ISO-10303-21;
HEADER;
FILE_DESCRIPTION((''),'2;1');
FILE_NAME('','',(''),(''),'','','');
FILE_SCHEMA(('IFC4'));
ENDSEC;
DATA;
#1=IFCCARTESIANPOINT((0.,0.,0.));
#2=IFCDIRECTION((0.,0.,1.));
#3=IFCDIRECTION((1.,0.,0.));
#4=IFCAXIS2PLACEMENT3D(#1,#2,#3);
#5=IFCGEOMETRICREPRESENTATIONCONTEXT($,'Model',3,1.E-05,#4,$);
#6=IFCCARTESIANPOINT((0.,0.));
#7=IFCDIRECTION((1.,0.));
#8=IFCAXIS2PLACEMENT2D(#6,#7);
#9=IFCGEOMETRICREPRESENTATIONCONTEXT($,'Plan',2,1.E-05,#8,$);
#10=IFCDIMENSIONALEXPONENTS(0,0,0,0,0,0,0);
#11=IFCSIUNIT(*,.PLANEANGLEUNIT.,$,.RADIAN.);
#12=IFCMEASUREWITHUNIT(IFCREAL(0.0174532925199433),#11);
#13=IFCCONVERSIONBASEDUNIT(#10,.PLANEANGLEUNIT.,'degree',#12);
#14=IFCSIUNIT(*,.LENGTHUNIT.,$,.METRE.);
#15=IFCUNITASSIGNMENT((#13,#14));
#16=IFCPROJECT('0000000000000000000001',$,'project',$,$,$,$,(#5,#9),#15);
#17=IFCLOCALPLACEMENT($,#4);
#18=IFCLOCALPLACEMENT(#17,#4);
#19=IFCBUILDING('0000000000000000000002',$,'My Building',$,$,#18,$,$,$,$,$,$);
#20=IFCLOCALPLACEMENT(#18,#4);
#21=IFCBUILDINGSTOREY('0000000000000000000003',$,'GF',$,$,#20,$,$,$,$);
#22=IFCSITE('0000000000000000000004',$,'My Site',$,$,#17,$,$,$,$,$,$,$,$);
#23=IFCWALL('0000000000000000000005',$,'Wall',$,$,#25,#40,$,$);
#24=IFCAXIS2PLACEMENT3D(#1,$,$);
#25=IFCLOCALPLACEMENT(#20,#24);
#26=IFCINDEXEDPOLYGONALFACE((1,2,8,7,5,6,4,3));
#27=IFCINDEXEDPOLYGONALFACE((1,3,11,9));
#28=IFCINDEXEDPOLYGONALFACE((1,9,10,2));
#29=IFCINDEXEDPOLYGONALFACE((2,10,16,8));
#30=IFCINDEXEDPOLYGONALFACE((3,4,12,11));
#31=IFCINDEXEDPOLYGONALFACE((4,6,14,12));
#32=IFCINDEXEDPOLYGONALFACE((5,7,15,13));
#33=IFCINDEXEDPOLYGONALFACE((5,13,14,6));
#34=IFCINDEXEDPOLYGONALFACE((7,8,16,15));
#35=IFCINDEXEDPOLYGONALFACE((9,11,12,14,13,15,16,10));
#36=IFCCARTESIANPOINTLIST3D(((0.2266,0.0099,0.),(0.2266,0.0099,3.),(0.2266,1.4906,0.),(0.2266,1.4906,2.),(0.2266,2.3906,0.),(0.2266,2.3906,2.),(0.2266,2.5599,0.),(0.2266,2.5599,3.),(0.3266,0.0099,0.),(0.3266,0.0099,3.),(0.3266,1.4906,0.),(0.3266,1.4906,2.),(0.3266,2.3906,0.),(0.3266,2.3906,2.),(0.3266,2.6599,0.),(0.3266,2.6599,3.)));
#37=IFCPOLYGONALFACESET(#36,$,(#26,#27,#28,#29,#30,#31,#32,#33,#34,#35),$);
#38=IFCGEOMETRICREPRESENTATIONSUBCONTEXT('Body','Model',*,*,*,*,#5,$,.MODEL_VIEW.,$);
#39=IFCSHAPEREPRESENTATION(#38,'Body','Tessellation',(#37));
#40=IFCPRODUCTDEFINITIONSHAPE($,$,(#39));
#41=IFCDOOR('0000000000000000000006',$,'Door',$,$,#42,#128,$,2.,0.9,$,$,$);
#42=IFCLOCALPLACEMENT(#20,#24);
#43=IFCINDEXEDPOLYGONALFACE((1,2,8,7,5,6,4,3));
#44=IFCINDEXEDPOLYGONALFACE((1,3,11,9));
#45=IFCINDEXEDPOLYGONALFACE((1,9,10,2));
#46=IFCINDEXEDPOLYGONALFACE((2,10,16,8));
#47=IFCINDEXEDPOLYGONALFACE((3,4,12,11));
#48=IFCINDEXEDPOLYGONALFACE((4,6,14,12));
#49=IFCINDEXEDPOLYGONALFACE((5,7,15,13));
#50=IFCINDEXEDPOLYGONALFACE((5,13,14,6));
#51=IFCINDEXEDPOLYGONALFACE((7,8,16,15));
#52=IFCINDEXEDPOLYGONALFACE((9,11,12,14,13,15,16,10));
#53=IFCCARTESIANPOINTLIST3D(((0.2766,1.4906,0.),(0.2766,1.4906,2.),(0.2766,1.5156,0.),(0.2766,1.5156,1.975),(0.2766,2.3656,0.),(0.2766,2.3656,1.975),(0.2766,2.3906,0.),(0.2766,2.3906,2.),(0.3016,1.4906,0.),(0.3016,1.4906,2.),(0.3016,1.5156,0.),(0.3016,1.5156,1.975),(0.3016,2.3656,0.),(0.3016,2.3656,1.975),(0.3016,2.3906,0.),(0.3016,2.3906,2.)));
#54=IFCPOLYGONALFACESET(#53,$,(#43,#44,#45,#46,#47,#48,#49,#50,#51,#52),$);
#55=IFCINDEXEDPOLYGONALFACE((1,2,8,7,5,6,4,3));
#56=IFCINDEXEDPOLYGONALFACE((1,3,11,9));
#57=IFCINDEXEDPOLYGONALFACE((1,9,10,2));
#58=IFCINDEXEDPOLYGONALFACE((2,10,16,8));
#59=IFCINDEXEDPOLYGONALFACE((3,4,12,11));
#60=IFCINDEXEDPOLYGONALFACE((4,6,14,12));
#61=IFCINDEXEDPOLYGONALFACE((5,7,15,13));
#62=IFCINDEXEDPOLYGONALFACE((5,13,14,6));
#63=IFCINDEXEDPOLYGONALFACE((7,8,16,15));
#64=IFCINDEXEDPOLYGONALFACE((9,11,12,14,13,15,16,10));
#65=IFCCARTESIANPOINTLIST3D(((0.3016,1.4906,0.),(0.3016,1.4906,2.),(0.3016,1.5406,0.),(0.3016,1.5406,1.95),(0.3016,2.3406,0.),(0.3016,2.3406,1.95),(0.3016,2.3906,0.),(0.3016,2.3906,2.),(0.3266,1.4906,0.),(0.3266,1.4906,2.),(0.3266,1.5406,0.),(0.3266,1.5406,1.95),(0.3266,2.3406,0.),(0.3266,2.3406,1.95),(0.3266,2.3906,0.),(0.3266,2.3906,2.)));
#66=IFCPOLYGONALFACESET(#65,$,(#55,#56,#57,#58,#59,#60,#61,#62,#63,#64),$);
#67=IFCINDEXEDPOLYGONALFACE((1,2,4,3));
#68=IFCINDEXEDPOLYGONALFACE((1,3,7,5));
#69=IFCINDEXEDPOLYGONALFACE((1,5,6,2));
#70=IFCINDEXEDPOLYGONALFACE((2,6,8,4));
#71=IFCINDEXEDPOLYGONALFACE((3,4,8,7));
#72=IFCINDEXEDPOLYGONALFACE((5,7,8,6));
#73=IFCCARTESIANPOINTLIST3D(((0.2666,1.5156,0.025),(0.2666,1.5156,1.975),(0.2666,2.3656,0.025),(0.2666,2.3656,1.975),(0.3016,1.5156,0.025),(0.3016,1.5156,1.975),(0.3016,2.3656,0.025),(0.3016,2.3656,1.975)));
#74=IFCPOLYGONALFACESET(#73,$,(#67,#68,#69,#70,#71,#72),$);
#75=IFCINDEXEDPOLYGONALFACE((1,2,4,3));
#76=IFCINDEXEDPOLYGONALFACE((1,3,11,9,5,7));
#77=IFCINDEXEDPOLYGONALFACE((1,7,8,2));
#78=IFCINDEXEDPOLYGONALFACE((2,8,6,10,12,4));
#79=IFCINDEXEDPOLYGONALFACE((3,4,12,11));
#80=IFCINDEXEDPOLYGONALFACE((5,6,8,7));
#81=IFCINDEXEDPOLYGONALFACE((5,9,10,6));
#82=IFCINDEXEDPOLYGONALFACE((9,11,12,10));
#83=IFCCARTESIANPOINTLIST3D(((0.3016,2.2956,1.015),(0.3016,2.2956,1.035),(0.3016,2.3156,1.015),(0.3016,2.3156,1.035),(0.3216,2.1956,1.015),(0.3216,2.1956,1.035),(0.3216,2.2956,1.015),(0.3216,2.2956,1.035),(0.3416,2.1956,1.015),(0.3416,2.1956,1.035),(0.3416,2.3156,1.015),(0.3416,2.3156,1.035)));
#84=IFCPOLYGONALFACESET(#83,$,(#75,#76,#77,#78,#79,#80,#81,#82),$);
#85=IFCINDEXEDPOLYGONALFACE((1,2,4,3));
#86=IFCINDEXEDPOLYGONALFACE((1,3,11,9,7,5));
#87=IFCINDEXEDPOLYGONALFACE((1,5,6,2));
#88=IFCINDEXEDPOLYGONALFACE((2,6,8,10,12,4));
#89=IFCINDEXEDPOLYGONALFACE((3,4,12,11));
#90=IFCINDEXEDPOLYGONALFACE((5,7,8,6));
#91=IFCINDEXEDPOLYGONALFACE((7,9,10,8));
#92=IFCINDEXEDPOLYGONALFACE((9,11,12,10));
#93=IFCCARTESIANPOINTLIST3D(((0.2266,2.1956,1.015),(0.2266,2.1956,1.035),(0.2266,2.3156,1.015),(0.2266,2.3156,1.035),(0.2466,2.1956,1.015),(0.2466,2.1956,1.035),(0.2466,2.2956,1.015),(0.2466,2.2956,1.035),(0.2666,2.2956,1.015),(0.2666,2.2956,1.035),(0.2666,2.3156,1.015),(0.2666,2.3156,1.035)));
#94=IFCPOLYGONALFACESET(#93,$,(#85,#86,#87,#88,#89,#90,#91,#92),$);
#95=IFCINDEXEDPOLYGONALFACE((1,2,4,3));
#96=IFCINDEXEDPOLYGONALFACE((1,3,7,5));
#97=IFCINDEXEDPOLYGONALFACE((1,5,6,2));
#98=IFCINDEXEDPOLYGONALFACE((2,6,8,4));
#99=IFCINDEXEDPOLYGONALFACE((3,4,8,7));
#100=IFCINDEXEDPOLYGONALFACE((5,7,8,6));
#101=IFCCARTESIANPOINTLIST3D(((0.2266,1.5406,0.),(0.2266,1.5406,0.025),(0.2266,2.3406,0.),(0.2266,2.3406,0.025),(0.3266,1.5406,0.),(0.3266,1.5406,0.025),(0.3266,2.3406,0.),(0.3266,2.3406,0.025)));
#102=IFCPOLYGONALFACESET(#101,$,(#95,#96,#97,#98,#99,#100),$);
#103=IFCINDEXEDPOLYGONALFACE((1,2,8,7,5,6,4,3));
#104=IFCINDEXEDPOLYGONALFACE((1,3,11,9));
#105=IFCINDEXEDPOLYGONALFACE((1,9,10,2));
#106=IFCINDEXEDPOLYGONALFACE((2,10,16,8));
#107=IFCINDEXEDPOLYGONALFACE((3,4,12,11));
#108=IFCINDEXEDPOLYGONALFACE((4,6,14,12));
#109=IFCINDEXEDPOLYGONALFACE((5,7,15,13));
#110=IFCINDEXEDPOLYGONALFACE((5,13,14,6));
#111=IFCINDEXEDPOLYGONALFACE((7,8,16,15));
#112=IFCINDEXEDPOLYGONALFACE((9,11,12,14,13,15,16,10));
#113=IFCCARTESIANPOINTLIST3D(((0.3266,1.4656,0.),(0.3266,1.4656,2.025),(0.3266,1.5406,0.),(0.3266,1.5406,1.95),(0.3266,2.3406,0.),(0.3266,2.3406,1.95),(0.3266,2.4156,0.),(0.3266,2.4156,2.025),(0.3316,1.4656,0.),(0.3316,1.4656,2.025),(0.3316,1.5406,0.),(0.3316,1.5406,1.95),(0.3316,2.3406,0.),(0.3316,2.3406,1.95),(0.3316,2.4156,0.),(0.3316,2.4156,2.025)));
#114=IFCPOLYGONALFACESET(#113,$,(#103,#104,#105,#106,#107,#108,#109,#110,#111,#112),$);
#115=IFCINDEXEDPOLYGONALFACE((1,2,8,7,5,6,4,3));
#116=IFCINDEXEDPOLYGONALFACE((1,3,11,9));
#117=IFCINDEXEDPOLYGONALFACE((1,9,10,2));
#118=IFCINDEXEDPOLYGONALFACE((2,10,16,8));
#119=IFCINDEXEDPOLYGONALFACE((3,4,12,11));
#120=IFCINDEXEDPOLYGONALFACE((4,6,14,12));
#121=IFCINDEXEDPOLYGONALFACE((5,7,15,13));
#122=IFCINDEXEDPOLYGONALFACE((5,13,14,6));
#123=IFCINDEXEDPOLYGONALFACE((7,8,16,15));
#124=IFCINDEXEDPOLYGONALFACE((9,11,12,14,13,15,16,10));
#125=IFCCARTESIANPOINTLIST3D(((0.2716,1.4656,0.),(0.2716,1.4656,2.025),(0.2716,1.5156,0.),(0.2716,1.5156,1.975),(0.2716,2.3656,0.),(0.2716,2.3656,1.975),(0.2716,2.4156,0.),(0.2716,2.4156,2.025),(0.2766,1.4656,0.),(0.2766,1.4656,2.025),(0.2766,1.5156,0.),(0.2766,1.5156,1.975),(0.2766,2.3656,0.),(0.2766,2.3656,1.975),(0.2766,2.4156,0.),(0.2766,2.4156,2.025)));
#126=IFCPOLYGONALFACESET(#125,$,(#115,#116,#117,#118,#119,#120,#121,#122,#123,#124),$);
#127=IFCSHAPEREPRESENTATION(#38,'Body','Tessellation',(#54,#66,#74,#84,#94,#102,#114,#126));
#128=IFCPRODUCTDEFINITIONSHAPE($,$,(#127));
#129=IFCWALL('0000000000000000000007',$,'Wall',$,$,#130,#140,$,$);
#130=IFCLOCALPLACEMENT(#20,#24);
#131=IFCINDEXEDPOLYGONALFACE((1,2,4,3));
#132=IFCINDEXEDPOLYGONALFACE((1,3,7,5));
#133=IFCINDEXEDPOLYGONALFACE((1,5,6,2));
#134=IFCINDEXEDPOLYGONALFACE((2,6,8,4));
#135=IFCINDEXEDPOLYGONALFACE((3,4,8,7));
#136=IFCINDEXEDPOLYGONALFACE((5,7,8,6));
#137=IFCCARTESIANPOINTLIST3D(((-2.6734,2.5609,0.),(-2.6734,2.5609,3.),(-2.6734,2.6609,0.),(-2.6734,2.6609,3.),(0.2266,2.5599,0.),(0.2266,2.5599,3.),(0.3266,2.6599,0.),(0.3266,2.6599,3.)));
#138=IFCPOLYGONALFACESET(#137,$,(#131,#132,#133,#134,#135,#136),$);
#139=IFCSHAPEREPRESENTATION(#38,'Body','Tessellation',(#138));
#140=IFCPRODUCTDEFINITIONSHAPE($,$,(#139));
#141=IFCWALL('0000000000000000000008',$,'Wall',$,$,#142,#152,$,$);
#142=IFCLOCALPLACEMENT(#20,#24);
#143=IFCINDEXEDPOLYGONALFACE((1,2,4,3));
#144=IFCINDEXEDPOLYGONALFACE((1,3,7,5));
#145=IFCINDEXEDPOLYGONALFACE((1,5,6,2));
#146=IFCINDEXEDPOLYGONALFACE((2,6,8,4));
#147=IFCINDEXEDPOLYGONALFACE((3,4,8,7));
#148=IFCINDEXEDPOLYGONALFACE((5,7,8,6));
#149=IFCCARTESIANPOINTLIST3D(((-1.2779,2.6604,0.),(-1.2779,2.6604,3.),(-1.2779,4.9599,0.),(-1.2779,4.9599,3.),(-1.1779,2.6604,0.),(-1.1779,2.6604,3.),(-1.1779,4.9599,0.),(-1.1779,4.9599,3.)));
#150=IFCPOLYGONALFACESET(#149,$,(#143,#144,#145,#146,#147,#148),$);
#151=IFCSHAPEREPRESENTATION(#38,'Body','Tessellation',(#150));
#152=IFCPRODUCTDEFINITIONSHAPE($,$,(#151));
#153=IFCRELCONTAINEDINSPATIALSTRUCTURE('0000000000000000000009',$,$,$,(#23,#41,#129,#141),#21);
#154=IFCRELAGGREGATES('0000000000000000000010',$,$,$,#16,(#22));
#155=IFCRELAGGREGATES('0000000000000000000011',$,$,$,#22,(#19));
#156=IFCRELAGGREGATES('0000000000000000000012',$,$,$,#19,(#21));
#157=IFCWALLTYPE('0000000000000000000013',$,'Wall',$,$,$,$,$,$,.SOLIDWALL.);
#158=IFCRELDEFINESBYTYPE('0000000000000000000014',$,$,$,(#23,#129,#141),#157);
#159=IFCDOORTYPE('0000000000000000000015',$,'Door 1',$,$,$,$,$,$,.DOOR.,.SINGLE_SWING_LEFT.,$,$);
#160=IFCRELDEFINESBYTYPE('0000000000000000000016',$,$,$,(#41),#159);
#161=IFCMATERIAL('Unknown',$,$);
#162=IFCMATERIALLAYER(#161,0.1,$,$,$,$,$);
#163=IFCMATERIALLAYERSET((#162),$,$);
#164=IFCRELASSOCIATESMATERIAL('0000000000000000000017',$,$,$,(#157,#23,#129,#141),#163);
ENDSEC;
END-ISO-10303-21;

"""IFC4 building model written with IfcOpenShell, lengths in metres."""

from ifc_helpers import new_model, entity, si_unit, converted_unit, frame, origin_with_axes, origin_2d_with_axis, place, context, subcontext, project, spatial, line, indexed_curve, outline, extrude, shape, source, transform, mapped, material, layer, layer_set, layer_usage, type_object, type_shapes, element, fill, save


model = new_model("IFC4")

# Units and contexts
model_context = context("Model", 3, precision=1e-05, world=origin_with_axes())
plan_context = context("Plan", 2, precision=1e-05, world=origin_2d_with_axis())
body_context_1 = subcontext(model_context, "Body", "Model", "MODEL_VIEW")
body_context_2 = subcontext(plan_context, "Body", "Plan", "PLAN_VIEW")
ifc_project = project(units=[converted_unit("PLANEANGLEUNIT", "degree", entity("IfcReal", 0.0174532925199433), si_unit("PLANEANGLEUNIT", "RADIAN"), dimensions=[0, 0, 0, 0, 0, 0, 0]), si_unit("LENGTHUNIT", "METRE")], contexts=[model_context, plan_context])

# Site, building, storey
site_placement = place(None, origin_with_axes())
site = spatial("IfcSite", under=ifc_project, at=site_placement, Name="My Site")
building_placement = place(site_placement, origin_with_axes())
building = spatial("IfcBuilding", under=site, at=building_placement, Name="My Building")
storey_placement = place(building_placement, origin_with_axes())
storey = spatial("IfcBuildingStorey", under=building, at=storey_placement, Name="GF")

# Shared definitions
ifc_material = material(Name="Unknown")

# Shared definitions
ifc_layer_1 = layer(ifc_material, 0.1)
ifc_layer_set_1 = layer_set([ifc_layer_1])
wall_type = type_object("IfcWallType", Name="Wall", PredefinedType="SOLIDWALL", material=ifc_layer_set_1)
shared_shape_1 = source(origin_with_axes(), body_context_1, "Body", "SweptSolid", [
    extrude(outline(indexed_curve([(0.0, 0.0), (0.9, 0.0), (0.9, 2.0), (0.0, 2.0)], segments=[line(1, 2, 3, 4, 1)])), frame((0.0, -0.6, 0.0), z_axis=(0.0, -1.0, 0.0), x_axis=(1.0, 0.0, 0.0)), (0.0, 0.0, -1.0), 1.2),
])
door_type = type_object("IfcDoorType", Name="Door 1", OperationType="SINGLE_SWING_LEFT", PredefinedType="DOOR")
shared_shape_2 = source(origin_with_axes(), body_context_1, "Body", "SweptSolid", [
    extrude(outline(indexed_curve([(0.0, 0.0), (0.0, 2.0), (0.9, 2.0), (0.9, 0.0), (0.875, 0.0), (0.875, 1.975), (0.025, 1.975), (0.025, 0.0)], segments=[line(1, 2, 3, 4, 5, 6, 7, 8, 1)])), frame((0.0, 0.025, 0.0), z_axis=(0.0, -1.0, 0.0), x_axis=(1.0, 0.0, 0.0)), (0.0, 0.0, -1.0), 0.025),
    extrude(outline(indexed_curve([(0.0, 0.0), (0.0, 2.0), (0.9, 2.0), (0.9, 0.0), (0.85, 0.0), (0.85, 1.95), (0.05, 1.95), (0.05, 0.0)], segments=[line(1, 2, 3, 4, 5, 6, 7, 8, 1)])), frame((0.0, 0.0, 0.0), z_axis=(0.0, -1.0, 0.0), x_axis=(1.0, 0.0, 0.0)), (0.0, 0.0, -1.0), 0.025),
    extrude(outline(indexed_curve([(0.0, 0.0), (0.85, 0.0), (0.85, 0.035), (0.0, 0.035)], segments=[line(1, 2, 3, 4, 1)])), frame((0.025, 0.025, 0.025), z_axis=(0.0, 0.0, 1.0), x_axis=(1.0, 0.0, 0.0)), (0.0, 0.0, 1.0), 1.95),
    extrude(outline(indexed_curve([(0.0, 0.0), (0.0, -0.04), (-0.12, -0.04), (-0.12, -0.02), (-0.02, -0.02), (-0.02, 0.0)], segments=[line(1, 2, 3, 4, 5, 6, 1)])), frame((0.825, 0.025, 1.015), z_axis=(0.0, 0.0, 1.0), x_axis=(1.0, 0.0, 0.0)), (0.0, 0.0, 1.0), 0.02),
    extrude(outline(indexed_curve([(0.0, 0.0), (0.0, 0.04), (-0.12, 0.04), (-0.12, 0.02), (-0.02, 0.02), (-0.02, 0.0)], segments=[line(1, 2, 3, 4, 5, 6, 1)])), frame((0.825, 0.06, 1.015), z_axis=(0.0, 0.0, 1.0), x_axis=(1.0, 0.0, 0.0)), (0.0, 0.0, 1.0), 0.02),
    extrude(outline(indexed_curve([(0.0, 0.0), (0.8, 0.0), (0.8, 0.1), (0.0, 0.1)], segments=[line(1, 2, 3, 4, 1)])), frame((0.05, 0.0, 0.0), z_axis=(0.0, 0.0, 1.0), x_axis=(1.0, 0.0, 0.0)), (0.0, 0.0, 1.0), 0.025),
    extrude(outline(indexed_curve([(0.0, 0.0), (0.0, 2.025), (0.95, 2.025), (0.95, 0.0), (0.875, 0.0), (0.875, 1.95), (0.075, 1.95), (0.075, 0.0)], segments=[line(1, 2, 3, 4, 5, 6, 7, 8, 1)])), frame((-0.025, -0.005, 0.0), z_axis=(0.0, -1.0, 0.0), x_axis=(1.0, 0.0, 0.0)), (0.0, 0.0, -1.0), 0.005),
    extrude(outline(indexed_curve([(0.0, 0.0), (0.0, 2.025), (0.95, 2.025), (0.95, 0.0), (0.9, 0.0), (0.9, 1.975), (0.05, 1.975), (0.05, 0.0)], segments=[line(1, 2, 3, 4, 5, 6, 7, 8, 1)])), frame((-0.025, 0.05, 0.0), z_axis=(0.0, -1.0, 0.0), x_axis=(1.0, 0.0, 0.0)), (0.0, 0.0, -1.0), 0.005),
])
shared_shape_3 = source(origin_with_axes(), body_context_2, "Body", "Curve2D", [
    entity("IfcIndexedPolyCurve", entity("IfcCartesianPointList2D", [[0.0, 0.0], [0.0, 0.05], [0.025, 0.05], [0.025, 0.025], [0.05, 0.025], [0.05, 0.0]]), [entity("IfcLineIndex", [1, 2, 3, 4, 5, 6, 1])]),
    entity("IfcIndexedPolyCurve", entity("IfcCartesianPointList2D", [[0.9, 0.0], [0.9, 0.05], [0.875, 0.05], [0.875, 0.025], [0.85, 0.025], [0.85, 0.0]]), [entity("IfcLineIndex", [1, 2, 3, 4, 5, 6, 1])]),
    entity("IfcTrimmedCurve", entity("IfcEllipse", entity("IfcAxis2Placement2D", entity("IfcCartesianPoint", [0.06, 0.05]), entity("IfcDirection", [1.0, 0.0])), 0.815, 0.85), [entity("IfcCartesianPoint", [0.875, 0.05])], [entity("IfcCartesianPoint", [0.06, 0.9])], True, "CARTESIAN"),
    entity("IfcIndexedPolyCurve", entity("IfcCartesianPointList2D", [[0.025, 0.05], [0.06, 0.05], [0.06, 0.9], [0.025, 0.9]]), [entity("IfcLineIndex", [1, 2, 3, 4, 1])]),
])
type_shapes(door_type, [shared_shape_2, shared_shape_3])

# Wall, opening, door
ifc_layer_usage_1 = layer_usage(ifc_layer_set_1, "AXIS2", "POSITIVE", 0.0)
wall_1_placement = place(storey_placement, frame((0.3266, 0.0099, 0.0), z_axis=(0.0, 0.0, 1.0), x_axis=(0.0, 1.0, 0.0)))
wall_1 = element("IfcWall", 1, at=wall_1_placement, inside=storey, type_object=wall_type, material=ifc_layer_usage_1, Name="Wall", context=body_context_1, shape_type="SweptSolid", body=[
    extrude(outline(indexed_curve([(0.0, 0.0), (0.0, 0.1), (2.55, 0.1), (2.65, 0.0)], segments=[line(1, 2, 3, 4, 1)])), origin_with_axes(), (0.0, 0.0, 1.0), 3.0),
])
opening_1_placement = place(wall_1_placement, frame((1.4807, 0.0, 0.0), z_axis=(0.0, 0.0, 1.0), x_axis=(1.0, 0.0, 0.0)))
opening_1 = element("IfcOpeningElement", 2, at=opening_1_placement, cuts=wall_1, PredefinedType="OPENING", context=body_context_1, shape_type="MappedRepresentation", body=[
    mapped(shared_shape_1, transform((0.0, 0.0, 0.0), x_axis=(1.0, 0.0, 0.0), y_axis=(0.0, 1.0, 0.0), z_axis=(0.0, 0.0, 1.0), scale=1.0)),
])
door_1_placement = place(opening_1_placement, frame((0.0, 0.0, 0.0), z_axis=(0.0, 0.0, 1.0), x_axis=(1.0, 0.0, 0.0)))
door_1 = element("IfcDoor", 3, at=door_1_placement, inside=storey, type_object=door_type, Name="Door", OverallHeight=2.0, OverallWidth=0.9, shapes=[
    shape(body_context_1, "Body", "MappedRepresentation", [mapped(shared_shape_2, transform((0.0, 0.0, 0.0), x_axis=(1.0, 0.0, 0.0), y_axis=(0.0, 1.0, 0.0), z_axis=(0.0, 0.0, 1.0), scale=1.0))]),
    shape(body_context_2, "Body", "MappedRepresentation", [mapped(shared_shape_3, transform((0.0, 0.0, 0.0), x_axis=(1.0, 0.0, 0.0), y_axis=(0.0, 1.0, 0.0), z_axis=(0.0, 0.0, 1.0), scale=1.0))]),
])
fill(opening_1, door_1)

# Walls
ifc_layer_usage_2 = layer_usage(ifc_layer_set_1, "AXIS2", "POSITIVE", 0.0)
wall_2_placement = place(storey_placement, frame((0.3266, 2.6599, 0.0), z_axis=(0.0, 0.0, 1.0), x_axis=(-1.0, 0.00034, 0.0)))
element("IfcWall", 4, at=wall_2_placement, inside=storey, type_object=wall_type, material=ifc_layer_usage_2, Name="Wall", context=body_context_1, shape_type="SweptSolid", body=[
    extrude(outline(indexed_curve([(0.0, 0.0), (0.1, 0.1), (3.0, 0.1), (3.0, 0.0)], segments=[line(1, 2, 3, 4, 1)])), origin_with_axes(), (0.0, 0.0, 1.0), 3.0),
])
ifc_layer_usage_3 = layer_usage(ifc_layer_set_1, "AXIS2", "POSITIVE", 0.0)
wall_3_placement = place(storey_placement, frame((-1.2779, 4.9599, 0.0), z_axis=(0.0, 0.0, 1.0), x_axis=(0.0, -1.0, 0.0)))
element("IfcWall", 5, at=wall_3_placement, inside=storey, type_object=wall_type, material=ifc_layer_usage_3, Name="Wall", context=body_context_1, shape_type="SweptSolid", body=[
    extrude(outline(indexed_curve([(0.0, 0.0), (0.0, 0.1), (2.2995, 0.1), (2.2995, 0.0)], segments=[line(1, 2, 3, 4, 1)])), origin_with_axes(), (0.0, 0.0, 1.0), 3.0),
])

save(model, "model.ifc")
